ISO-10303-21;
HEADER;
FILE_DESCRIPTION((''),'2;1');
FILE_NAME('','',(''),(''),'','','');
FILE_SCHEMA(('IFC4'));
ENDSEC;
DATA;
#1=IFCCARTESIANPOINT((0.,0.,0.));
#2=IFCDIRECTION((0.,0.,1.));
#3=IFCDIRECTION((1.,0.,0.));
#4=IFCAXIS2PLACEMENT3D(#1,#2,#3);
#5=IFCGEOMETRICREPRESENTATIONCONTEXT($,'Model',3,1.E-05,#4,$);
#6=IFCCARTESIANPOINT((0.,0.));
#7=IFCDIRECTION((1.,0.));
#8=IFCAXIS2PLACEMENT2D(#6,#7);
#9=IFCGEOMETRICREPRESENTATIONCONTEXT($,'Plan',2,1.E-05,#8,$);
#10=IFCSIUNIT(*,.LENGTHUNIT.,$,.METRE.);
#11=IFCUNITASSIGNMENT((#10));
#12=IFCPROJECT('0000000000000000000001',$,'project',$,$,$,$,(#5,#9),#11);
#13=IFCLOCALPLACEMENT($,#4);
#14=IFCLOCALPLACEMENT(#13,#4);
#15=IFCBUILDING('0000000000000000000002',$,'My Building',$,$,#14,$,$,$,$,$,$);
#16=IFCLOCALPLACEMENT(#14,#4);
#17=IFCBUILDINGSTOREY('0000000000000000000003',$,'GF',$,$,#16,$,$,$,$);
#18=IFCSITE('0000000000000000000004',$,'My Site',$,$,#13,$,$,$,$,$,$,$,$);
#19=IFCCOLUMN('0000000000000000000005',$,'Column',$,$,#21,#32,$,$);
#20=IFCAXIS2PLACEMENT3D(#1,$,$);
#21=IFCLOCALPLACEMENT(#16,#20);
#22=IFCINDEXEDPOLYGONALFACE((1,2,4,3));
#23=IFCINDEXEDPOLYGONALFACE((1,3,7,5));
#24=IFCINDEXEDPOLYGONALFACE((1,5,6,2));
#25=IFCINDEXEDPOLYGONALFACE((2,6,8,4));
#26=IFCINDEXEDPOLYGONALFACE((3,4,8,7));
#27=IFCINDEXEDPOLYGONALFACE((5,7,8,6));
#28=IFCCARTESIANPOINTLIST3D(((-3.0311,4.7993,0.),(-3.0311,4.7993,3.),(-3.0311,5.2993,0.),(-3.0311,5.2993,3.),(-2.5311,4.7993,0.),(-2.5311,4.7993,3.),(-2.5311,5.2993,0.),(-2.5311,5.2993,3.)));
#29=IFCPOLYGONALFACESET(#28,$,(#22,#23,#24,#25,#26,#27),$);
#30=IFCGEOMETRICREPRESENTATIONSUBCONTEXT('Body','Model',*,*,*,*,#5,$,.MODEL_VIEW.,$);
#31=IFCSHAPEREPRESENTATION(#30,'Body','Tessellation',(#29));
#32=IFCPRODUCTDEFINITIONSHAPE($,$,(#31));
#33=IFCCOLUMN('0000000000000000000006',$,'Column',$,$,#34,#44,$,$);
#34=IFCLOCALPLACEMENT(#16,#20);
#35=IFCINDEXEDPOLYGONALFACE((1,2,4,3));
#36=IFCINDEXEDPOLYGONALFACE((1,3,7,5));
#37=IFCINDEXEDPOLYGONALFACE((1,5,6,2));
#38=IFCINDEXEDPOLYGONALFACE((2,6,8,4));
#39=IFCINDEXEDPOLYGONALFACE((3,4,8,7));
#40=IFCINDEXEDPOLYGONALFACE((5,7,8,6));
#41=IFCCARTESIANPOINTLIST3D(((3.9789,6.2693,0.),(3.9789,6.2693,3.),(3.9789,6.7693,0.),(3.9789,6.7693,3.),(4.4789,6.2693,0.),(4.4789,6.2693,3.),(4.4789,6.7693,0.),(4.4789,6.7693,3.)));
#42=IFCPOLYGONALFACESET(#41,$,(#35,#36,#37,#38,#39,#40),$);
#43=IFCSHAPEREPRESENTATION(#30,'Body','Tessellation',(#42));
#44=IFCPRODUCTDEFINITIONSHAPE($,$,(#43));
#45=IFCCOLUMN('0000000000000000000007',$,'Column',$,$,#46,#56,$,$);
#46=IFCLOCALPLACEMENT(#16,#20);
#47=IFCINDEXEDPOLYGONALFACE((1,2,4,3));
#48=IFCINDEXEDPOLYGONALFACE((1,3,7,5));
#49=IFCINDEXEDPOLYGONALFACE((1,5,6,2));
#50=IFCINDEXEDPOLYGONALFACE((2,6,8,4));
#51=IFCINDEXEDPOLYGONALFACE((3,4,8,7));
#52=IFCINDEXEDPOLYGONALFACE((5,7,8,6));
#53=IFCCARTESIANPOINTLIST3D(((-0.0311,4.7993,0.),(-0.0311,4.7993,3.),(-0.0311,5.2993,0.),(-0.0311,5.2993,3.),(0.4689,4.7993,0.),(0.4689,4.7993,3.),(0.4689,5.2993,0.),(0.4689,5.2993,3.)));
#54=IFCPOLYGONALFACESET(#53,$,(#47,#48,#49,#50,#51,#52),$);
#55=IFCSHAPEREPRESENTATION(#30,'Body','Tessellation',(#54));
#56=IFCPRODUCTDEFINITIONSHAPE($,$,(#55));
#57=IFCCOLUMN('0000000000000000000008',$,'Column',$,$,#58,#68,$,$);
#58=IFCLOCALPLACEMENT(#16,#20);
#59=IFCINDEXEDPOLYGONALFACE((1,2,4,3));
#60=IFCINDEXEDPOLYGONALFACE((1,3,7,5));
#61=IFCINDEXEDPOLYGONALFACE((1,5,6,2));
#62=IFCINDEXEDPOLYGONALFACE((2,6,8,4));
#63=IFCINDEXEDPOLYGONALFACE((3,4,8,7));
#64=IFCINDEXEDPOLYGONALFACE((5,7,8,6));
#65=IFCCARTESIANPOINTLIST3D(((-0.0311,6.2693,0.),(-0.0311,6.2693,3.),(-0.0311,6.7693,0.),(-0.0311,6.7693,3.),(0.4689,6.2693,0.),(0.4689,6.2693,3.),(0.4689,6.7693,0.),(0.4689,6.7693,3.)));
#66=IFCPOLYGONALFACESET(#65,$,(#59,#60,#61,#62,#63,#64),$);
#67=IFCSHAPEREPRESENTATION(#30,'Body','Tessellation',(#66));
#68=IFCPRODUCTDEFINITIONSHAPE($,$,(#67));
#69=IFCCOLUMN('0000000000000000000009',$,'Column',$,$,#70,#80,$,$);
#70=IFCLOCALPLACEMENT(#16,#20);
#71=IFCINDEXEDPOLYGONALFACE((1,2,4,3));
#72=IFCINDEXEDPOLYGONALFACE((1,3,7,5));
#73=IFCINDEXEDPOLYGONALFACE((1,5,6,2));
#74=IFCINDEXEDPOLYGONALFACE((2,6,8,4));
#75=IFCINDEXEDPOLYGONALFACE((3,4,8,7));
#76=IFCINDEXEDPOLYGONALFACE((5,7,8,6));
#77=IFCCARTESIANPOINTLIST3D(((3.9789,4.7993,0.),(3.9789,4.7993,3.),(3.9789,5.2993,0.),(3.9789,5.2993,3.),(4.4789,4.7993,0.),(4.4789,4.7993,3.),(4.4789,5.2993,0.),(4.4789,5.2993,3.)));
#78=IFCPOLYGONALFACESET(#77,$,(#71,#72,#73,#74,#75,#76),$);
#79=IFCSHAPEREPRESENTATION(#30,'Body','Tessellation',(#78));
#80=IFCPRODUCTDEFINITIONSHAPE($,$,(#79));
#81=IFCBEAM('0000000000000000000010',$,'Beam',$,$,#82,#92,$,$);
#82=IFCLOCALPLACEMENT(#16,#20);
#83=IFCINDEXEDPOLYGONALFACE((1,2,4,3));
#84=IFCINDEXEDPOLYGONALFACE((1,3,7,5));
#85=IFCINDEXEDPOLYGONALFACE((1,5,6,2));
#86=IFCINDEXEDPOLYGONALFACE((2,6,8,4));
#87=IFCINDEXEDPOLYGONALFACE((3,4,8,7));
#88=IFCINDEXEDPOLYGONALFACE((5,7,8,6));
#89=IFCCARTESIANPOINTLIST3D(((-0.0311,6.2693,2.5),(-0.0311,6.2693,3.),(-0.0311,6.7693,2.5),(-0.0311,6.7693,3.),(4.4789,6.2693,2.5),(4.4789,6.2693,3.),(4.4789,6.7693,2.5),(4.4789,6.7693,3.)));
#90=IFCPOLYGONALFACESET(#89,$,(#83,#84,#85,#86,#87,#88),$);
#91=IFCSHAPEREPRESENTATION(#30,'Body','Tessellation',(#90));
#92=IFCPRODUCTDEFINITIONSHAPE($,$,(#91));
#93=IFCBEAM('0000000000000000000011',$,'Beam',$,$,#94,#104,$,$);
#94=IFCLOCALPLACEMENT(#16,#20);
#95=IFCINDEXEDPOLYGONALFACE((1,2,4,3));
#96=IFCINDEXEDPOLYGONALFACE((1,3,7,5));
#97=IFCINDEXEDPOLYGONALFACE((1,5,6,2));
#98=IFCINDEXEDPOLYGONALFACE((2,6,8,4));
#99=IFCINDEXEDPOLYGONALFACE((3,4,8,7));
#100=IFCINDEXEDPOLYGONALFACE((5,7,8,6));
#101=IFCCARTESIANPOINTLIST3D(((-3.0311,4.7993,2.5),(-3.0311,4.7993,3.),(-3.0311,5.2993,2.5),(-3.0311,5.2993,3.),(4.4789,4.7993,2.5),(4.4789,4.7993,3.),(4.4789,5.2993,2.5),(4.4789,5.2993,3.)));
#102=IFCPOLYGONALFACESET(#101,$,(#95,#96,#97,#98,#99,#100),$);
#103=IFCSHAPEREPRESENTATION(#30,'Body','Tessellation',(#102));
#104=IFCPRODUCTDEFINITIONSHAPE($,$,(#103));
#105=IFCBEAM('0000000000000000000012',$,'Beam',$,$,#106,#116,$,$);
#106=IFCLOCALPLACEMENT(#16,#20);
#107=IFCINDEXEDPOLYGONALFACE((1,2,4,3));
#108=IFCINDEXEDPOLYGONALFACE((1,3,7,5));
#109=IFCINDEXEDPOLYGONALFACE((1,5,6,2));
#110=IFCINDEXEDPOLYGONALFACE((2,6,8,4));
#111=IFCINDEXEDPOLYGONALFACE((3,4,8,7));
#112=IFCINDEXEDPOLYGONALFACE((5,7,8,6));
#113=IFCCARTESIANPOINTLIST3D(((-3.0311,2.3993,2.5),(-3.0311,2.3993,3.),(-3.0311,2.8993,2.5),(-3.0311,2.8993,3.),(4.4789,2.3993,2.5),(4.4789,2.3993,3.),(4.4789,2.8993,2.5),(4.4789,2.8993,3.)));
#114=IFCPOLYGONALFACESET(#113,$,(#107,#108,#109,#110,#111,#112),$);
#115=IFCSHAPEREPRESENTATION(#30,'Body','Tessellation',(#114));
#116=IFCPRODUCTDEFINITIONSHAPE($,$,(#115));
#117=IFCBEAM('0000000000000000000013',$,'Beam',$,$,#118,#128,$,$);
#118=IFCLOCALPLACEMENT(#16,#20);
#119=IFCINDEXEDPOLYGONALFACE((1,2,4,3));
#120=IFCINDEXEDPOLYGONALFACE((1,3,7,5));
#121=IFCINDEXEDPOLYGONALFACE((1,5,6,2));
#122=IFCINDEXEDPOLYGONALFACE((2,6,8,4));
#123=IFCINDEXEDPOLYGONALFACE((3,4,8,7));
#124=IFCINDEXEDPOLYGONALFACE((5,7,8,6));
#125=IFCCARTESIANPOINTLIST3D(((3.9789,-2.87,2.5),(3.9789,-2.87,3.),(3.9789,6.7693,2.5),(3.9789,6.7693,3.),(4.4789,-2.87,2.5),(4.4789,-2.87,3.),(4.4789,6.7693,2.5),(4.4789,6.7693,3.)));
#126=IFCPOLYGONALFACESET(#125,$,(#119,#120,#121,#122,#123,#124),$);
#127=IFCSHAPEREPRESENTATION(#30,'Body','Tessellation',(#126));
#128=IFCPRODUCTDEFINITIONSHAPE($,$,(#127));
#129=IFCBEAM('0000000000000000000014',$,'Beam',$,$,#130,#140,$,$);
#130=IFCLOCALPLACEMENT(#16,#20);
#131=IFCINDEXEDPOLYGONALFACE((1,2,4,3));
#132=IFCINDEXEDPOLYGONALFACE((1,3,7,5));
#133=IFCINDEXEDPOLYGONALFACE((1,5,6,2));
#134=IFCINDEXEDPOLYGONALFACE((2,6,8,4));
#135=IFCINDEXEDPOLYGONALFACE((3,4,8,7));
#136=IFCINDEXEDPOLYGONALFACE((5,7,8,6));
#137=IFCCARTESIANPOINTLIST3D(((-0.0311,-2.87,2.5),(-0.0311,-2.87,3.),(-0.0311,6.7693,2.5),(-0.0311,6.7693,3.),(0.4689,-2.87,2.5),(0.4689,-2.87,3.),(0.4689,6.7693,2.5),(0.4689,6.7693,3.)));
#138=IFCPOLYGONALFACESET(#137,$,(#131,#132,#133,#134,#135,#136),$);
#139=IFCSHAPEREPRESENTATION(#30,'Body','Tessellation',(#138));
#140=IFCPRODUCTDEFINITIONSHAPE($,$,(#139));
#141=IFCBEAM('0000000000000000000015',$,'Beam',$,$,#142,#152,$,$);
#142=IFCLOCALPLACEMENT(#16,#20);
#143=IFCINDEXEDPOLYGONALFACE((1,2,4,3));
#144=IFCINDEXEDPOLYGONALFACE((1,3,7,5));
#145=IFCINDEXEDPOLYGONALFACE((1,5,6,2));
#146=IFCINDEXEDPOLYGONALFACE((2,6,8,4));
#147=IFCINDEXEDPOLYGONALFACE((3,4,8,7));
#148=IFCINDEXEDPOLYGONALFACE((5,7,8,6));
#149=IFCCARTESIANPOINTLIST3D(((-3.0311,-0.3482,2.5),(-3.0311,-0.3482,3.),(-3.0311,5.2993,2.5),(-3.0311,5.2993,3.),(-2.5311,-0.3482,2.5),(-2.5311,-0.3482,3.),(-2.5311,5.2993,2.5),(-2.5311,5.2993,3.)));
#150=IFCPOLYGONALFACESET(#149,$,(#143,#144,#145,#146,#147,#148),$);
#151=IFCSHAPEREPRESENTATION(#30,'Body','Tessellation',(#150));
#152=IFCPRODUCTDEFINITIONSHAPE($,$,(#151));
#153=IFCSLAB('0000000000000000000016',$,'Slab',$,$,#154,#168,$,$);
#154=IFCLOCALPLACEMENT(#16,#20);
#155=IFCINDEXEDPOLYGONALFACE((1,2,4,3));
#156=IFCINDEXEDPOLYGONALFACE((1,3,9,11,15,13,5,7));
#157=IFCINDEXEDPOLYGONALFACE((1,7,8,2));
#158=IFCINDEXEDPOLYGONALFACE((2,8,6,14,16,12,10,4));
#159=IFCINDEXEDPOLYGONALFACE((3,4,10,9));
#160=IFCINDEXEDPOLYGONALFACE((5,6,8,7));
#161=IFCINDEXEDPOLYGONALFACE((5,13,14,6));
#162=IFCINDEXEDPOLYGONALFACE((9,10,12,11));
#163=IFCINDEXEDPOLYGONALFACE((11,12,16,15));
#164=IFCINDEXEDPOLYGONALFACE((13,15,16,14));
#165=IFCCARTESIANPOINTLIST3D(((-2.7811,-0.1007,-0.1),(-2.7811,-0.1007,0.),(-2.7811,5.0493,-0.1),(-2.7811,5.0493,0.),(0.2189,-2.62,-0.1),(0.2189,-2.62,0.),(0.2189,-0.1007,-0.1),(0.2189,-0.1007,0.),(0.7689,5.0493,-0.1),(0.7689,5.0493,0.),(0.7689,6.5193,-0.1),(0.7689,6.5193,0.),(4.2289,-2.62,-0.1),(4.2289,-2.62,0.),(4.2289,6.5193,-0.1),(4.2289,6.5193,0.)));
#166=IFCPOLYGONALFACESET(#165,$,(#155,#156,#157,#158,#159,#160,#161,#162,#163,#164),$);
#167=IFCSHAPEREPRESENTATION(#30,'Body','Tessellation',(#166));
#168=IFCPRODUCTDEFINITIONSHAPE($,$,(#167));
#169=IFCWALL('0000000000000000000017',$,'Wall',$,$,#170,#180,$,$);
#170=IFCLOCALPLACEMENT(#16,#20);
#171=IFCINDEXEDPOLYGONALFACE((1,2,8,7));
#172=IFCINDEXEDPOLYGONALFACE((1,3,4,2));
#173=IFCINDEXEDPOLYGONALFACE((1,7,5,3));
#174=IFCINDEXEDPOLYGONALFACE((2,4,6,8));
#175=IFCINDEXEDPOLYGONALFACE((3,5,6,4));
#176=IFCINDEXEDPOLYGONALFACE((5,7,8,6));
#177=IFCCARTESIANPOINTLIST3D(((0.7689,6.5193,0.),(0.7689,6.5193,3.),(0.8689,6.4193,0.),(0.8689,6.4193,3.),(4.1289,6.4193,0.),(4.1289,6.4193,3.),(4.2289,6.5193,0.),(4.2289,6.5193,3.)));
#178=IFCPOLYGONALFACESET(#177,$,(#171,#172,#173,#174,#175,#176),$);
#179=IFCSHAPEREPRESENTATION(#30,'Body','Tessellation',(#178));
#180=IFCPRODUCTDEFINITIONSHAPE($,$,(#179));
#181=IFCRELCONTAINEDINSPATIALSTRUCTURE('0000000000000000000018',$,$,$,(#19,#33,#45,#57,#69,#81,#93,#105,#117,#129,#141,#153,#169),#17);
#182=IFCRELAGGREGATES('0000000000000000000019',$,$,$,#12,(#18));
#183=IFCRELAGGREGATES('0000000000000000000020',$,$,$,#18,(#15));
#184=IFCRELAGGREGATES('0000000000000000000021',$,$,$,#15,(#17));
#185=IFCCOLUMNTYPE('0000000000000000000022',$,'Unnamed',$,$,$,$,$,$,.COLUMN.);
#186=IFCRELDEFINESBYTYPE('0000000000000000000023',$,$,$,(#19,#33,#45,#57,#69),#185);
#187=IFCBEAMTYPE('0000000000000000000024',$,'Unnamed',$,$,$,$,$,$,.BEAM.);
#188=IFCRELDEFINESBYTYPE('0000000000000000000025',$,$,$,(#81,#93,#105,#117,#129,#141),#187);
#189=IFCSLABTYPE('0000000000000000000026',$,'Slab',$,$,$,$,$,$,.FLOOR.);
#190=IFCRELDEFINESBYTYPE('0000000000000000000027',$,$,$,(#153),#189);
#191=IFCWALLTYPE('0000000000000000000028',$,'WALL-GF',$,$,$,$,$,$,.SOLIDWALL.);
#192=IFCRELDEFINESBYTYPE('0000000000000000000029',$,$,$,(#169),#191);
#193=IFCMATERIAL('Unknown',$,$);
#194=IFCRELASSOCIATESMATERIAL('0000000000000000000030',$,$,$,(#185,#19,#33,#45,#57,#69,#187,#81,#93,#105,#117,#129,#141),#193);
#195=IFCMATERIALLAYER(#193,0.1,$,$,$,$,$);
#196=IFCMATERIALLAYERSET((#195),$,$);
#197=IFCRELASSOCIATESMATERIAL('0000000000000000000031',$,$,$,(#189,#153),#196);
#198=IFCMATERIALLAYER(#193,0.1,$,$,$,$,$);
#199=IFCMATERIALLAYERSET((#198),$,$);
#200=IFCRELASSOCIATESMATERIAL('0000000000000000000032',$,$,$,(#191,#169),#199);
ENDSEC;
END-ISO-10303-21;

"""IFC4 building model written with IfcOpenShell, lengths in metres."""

from ifc_helpers import new_model, si_unit, frame, origin_with_axes, origin_2d_with_axis, place, context, subcontext, project, spatial, line, indexed_curve, rectangle, outline, extrude, material, layer, layer_set, layer_usage, material_profile, profile_set, profile_usage, type_object, element, save


model = new_model("IFC4")

# Units and contexts
model_context = context("Model", 3, precision=1e-05, world=origin_with_axes())
plan_context = context("Plan", 2, precision=1e-05, world=origin_2d_with_axis())
body_context_1 = subcontext(model_context, "Body", "Model", "MODEL_VIEW")
ifc_project = project(units=[si_unit("LENGTHUNIT", "METRE")], contexts=[model_context, plan_context])

# Site, building, storey
site_placement = place(None, origin_with_axes())
site = spatial("IfcSite", under=ifc_project, at=site_placement, Name="My Site")
building_placement = place(site_placement, origin_with_axes())
building = spatial("IfcBuilding", under=site, at=building_placement, Name="My Building")
storey_placement = place(building_placement, origin_with_axes())
storey = spatial("IfcBuildingStorey", under=building, at=storey_placement, Name="GF")

# Columns
ifc_material_1 = material(Name="Unknown")
ifc_material_profile_1 = material_profile(ifc_material_1, rectangle(XDim=0.5, YDim=0.5))
ifc_profile_set_1 = profile_set([ifc_material_profile_1])
ifc_profile_usage_1 = profile_usage(ifc_profile_set_1, cardinal=5)
column_type = type_object("IfcColumnType", Name="Unnamed", PredefinedType="COLUMN", material=ifc_profile_set_1)
column_1_placement = place(storey_placement, frame((-2.7811, 5.0493, 0.0), z_axis=(0.0, 0.0, 1.0), x_axis=(1.0, 0.0, 0.0)))
element("IfcColumn", 1, at=column_1_placement, inside=storey, type_object=column_type, material=ifc_profile_usage_1, Name="Column", context=body_context_1, shape_type="SweptSolid", body=[
    extrude(rectangle(XDim=0.5, YDim=0.5), origin_with_axes(), (0.0, 0.0, 1.0), 3.0),
])
ifc_profile_usage_2 = profile_usage(ifc_profile_set_1, cardinal=5)
column_2_placement = place(storey_placement, frame((4.2289, 6.5193, 0.0), z_axis=(0.0, 0.0, 1.0), x_axis=(1.0, 0.0, 0.0)))
element("IfcColumn", 2, at=column_2_placement, inside=storey, type_object=column_type, material=ifc_profile_usage_2, Name="Column", context=body_context_1, shape_type="SweptSolid", body=[
    extrude(rectangle(XDim=0.5, YDim=0.5), origin_with_axes(), (0.0, 0.0, 1.0), 3.0),
])
ifc_profile_usage_3 = profile_usage(ifc_profile_set_1, cardinal=5)
column_3_placement = place(storey_placement, frame((0.2189, 5.0493, 0.0), z_axis=(0.0, 0.0, 1.0), x_axis=(1.0, 0.0, 0.0)))
element("IfcColumn", 3, at=column_3_placement, inside=storey, type_object=column_type, material=ifc_profile_usage_3, Name="Column", context=body_context_1, shape_type="SweptSolid", body=[
    extrude(rectangle(XDim=0.5, YDim=0.5), origin_with_axes(), (0.0, 0.0, 1.0), 3.0),
])
ifc_profile_usage_4 = profile_usage(ifc_profile_set_1, cardinal=5)
column_4_placement = place(storey_placement, frame((0.2189, 6.5193, 0.0), z_axis=(0.0, 0.0, 1.0), x_axis=(1.0, 0.0, 0.0)))
element("IfcColumn", 4, at=column_4_placement, inside=storey, type_object=column_type, material=ifc_profile_usage_4, Name="Column", context=body_context_1, shape_type="SweptSolid", body=[
    extrude(rectangle(XDim=0.5, YDim=0.5), origin_with_axes(), (0.0, 0.0, 1.0), 3.0),
])
ifc_profile_usage_5 = profile_usage(ifc_profile_set_1, cardinal=5)
column_5_placement = place(storey_placement, frame((4.2289, 5.0493, 0.0), z_axis=(0.0, 0.0, 1.0), x_axis=(1.0, 0.0, 0.0)))
element("IfcColumn", 5, at=column_5_placement, inside=storey, type_object=column_type, material=ifc_profile_usage_5, Name="Column", context=body_context_1, shape_type="SweptSolid", body=[
    extrude(rectangle(XDim=0.5, YDim=0.5), origin_with_axes(), (0.0, 0.0, 1.0), 3.0),
])

# Beams
ifc_material_profile_2 = material_profile(ifc_material_1, rectangle(XDim=0.5, YDim=0.5))
ifc_profile_set_2 = profile_set([ifc_material_profile_2])
ifc_profile_usage_6 = profile_usage(ifc_profile_set_2, cardinal=7)
beam_type = type_object("IfcBeamType", Name="Unnamed", PredefinedType="BEAM", material=ifc_profile_set_2)
beam_1_placement = place(storey_placement, frame((-0.0311, 6.7693, 3.0), z_axis=(1.0, -0.000001, 0.000001), x_axis=(0.000001, 1.0, 0.0)))
element("IfcBeam", 6, at=beam_1_placement, inside=storey, type_object=beam_type, material=ifc_profile_usage_6, Name="Beam", context=body_context_1, shape_type="SweptSolid", body=[
    extrude(rectangle(XDim=0.5, YDim=0.5), frame((-0.25, -0.25, 0.0), z_axis=(0.0, 0.0, 1.0), x_axis=(1.0, 0.0, 0.0)), (0.0, 0.0, 1.0), 4.51),
])
ifc_profile_usage_7 = profile_usage(ifc_profile_set_2, cardinal=7)
beam_2_placement = place(storey_placement, frame((-3.0311, 5.2993, 3.0), z_axis=(1.0, -0.000001, 0.000001), x_axis=(0.000001, 1.0, 0.0)))
element("IfcBeam", 7, at=beam_2_placement, inside=storey, type_object=beam_type, material=ifc_profile_usage_7, Name="Beam", context=body_context_1, shape_type="SweptSolid", body=[
    extrude(rectangle(XDim=0.5, YDim=0.5), frame((-0.25, -0.25, 0.0), z_axis=(0.0, 0.0, 1.0), x_axis=(1.0, 0.0, 0.0)), (0.0, 0.0, 1.0), 7.51),
])
ifc_profile_usage_8 = profile_usage(ifc_profile_set_2, cardinal=7)
beam_3_placement = place(storey_placement, frame((-3.0311, 2.8993, 3.0), z_axis=(1.0, 0.0, 0.0), x_axis=(0.0, 1.0, 0.0)))
element("IfcBeam", 8, at=beam_3_placement, inside=storey, type_object=beam_type, material=ifc_profile_usage_8, Name="Beam", context=body_context_1, shape_type="SweptSolid", body=[
    extrude(rectangle(XDim=0.5, YDim=0.5), frame((-0.25, -0.25, 0.0), z_axis=(0.0, 0.0, 1.0), x_axis=(1.0, 0.0, 0.0)), (0.0, 0.0, 1.0), 7.51),
])
ifc_profile_usage_9 = profile_usage(ifc_profile_set_2, cardinal=7)
beam_4_placement = place(storey_placement, frame((4.4789, 6.7693, 3.0), z_axis=(0.0, -1.0, 0.0), x_axis=(1.0, 0.0, 0.0)))
element("IfcBeam", 9, at=beam_4_placement, inside=storey, type_object=beam_type, material=ifc_profile_usage_9, Name="Beam", context=body_context_1, shape_type="SweptSolid", body=[
    extrude(rectangle(XDim=0.5, YDim=0.5), frame((-0.25, -0.25, 0.0), z_axis=(0.0, 0.0, 1.0), x_axis=(1.0, 0.0, 0.0)), (0.0, 0.0, 1.0), 9.6393),
])
ifc_profile_usage_10 = profile_usage(ifc_profile_set_2, cardinal=7)
beam_5_placement = place(storey_placement, frame((0.4689, 6.7693, 3.0), z_axis=(0.0, -1.0, 0.0), x_axis=(1.0, 0.0, 0.0)))
element("IfcBeam", 10, at=beam_5_placement, inside=storey, type_object=beam_type, material=ifc_profile_usage_10, Name="Beam", context=body_context_1, shape_type="SweptSolid", body=[
    extrude(rectangle(XDim=0.5, YDim=0.5), frame((-0.25, -0.25, 0.0), z_axis=(0.0, 0.0, 1.0), x_axis=(1.0, 0.0, 0.0)), (0.0, 0.0, 1.0), 9.6393),
])
ifc_profile_usage_11 = profile_usage(ifc_profile_set_2, cardinal=7)
beam_6_placement = place(storey_placement, frame((-2.5311, 5.2993, 3.0), z_axis=(0.0, -1.0, 0.0), x_axis=(1.0, 0.0, 0.0)))
element("IfcBeam", 11, at=beam_6_placement, inside=storey, type_object=beam_type, material=ifc_profile_usage_11, Name="Beam", context=body_context_1, shape_type="SweptSolid", body=[
    extrude(rectangle(XDim=0.5, YDim=0.5), frame((-0.25, -0.25, 0.0), z_axis=(0.0, 0.0, 1.0), x_axis=(1.0, 0.0, 0.0)), (0.0, 0.0, 1.0), 5.6474),
])

# Slab
ifc_layer_1 = layer(ifc_material_1, 0.1)
ifc_layer_set_1 = layer_set([ifc_layer_1])
ifc_layer_usage_1 = layer_usage(ifc_layer_set_1, "AXIS3", "POSITIVE", -0.1)
slab_type = type_object("IfcSlabType", Name="Slab", PredefinedType="FLOOR", material=ifc_layer_set_1)
slab_placement = place(storey_placement, frame((4.2289, 6.5193, 0.0), z_axis=(0.0, 0.0, 1.0), x_axis=(1.0, 0.0, 0.0)))
element("IfcSlab", 12, at=slab_placement, inside=storey, type_object=slab_type, material=ifc_layer_usage_1, Name="Slab", context=body_context_1, shape_type="SweptSolid", body=[
    extrude(outline(indexed_curve([(0.0, 0.0), (-3.46, 0.0), (-3.46, -1.47), (-7.01, -1.47), (-7.01, -6.62), (-4.01, -6.62), (-4.01, -9.1393), (0.0, -9.1393), (0.0, 0.0)])), frame((0.0, 0.0, -0.1), z_axis=(0.0, 0.0, 1.0), x_axis=(1.0, 0.0, 0.0)), (0.0, 0.0, 1.0), 0.1),
])

# Wall
ifc_layer_2 = layer(ifc_material_1, 0.1)
ifc_layer_set_2 = layer_set([ifc_layer_2])
ifc_layer_usage_2 = layer_usage(ifc_layer_set_2, "AXIS2", "POSITIVE", 0.0)
wall_type = type_object("IfcWallType", Name="WALL-GF", PredefinedType="SOLIDWALL", material=ifc_layer_set_2)
wall_1_placement = place(storey_placement, frame((4.2289, 6.5193, 0.0), z_axis=(0.0, 0.0, 1.0), x_axis=(-1.0, 0.0, 0.0)))
element("IfcWall", 13, at=wall_1_placement, inside=storey, type_object=wall_type, material=ifc_layer_usage_2, Name="Wall", context=body_context_1, shape_type="SweptSolid", body=[
    extrude(outline(indexed_curve([(0.0, 0.0), (0.1, 0.1), (3.36, 0.1), (3.46, 0.0)], segments=[line(1, 2, 3, 4, 1)])), origin_with_axes(), (0.0, 0.0, 1.0), 3.0),
])

save(model, "model.ifc")
